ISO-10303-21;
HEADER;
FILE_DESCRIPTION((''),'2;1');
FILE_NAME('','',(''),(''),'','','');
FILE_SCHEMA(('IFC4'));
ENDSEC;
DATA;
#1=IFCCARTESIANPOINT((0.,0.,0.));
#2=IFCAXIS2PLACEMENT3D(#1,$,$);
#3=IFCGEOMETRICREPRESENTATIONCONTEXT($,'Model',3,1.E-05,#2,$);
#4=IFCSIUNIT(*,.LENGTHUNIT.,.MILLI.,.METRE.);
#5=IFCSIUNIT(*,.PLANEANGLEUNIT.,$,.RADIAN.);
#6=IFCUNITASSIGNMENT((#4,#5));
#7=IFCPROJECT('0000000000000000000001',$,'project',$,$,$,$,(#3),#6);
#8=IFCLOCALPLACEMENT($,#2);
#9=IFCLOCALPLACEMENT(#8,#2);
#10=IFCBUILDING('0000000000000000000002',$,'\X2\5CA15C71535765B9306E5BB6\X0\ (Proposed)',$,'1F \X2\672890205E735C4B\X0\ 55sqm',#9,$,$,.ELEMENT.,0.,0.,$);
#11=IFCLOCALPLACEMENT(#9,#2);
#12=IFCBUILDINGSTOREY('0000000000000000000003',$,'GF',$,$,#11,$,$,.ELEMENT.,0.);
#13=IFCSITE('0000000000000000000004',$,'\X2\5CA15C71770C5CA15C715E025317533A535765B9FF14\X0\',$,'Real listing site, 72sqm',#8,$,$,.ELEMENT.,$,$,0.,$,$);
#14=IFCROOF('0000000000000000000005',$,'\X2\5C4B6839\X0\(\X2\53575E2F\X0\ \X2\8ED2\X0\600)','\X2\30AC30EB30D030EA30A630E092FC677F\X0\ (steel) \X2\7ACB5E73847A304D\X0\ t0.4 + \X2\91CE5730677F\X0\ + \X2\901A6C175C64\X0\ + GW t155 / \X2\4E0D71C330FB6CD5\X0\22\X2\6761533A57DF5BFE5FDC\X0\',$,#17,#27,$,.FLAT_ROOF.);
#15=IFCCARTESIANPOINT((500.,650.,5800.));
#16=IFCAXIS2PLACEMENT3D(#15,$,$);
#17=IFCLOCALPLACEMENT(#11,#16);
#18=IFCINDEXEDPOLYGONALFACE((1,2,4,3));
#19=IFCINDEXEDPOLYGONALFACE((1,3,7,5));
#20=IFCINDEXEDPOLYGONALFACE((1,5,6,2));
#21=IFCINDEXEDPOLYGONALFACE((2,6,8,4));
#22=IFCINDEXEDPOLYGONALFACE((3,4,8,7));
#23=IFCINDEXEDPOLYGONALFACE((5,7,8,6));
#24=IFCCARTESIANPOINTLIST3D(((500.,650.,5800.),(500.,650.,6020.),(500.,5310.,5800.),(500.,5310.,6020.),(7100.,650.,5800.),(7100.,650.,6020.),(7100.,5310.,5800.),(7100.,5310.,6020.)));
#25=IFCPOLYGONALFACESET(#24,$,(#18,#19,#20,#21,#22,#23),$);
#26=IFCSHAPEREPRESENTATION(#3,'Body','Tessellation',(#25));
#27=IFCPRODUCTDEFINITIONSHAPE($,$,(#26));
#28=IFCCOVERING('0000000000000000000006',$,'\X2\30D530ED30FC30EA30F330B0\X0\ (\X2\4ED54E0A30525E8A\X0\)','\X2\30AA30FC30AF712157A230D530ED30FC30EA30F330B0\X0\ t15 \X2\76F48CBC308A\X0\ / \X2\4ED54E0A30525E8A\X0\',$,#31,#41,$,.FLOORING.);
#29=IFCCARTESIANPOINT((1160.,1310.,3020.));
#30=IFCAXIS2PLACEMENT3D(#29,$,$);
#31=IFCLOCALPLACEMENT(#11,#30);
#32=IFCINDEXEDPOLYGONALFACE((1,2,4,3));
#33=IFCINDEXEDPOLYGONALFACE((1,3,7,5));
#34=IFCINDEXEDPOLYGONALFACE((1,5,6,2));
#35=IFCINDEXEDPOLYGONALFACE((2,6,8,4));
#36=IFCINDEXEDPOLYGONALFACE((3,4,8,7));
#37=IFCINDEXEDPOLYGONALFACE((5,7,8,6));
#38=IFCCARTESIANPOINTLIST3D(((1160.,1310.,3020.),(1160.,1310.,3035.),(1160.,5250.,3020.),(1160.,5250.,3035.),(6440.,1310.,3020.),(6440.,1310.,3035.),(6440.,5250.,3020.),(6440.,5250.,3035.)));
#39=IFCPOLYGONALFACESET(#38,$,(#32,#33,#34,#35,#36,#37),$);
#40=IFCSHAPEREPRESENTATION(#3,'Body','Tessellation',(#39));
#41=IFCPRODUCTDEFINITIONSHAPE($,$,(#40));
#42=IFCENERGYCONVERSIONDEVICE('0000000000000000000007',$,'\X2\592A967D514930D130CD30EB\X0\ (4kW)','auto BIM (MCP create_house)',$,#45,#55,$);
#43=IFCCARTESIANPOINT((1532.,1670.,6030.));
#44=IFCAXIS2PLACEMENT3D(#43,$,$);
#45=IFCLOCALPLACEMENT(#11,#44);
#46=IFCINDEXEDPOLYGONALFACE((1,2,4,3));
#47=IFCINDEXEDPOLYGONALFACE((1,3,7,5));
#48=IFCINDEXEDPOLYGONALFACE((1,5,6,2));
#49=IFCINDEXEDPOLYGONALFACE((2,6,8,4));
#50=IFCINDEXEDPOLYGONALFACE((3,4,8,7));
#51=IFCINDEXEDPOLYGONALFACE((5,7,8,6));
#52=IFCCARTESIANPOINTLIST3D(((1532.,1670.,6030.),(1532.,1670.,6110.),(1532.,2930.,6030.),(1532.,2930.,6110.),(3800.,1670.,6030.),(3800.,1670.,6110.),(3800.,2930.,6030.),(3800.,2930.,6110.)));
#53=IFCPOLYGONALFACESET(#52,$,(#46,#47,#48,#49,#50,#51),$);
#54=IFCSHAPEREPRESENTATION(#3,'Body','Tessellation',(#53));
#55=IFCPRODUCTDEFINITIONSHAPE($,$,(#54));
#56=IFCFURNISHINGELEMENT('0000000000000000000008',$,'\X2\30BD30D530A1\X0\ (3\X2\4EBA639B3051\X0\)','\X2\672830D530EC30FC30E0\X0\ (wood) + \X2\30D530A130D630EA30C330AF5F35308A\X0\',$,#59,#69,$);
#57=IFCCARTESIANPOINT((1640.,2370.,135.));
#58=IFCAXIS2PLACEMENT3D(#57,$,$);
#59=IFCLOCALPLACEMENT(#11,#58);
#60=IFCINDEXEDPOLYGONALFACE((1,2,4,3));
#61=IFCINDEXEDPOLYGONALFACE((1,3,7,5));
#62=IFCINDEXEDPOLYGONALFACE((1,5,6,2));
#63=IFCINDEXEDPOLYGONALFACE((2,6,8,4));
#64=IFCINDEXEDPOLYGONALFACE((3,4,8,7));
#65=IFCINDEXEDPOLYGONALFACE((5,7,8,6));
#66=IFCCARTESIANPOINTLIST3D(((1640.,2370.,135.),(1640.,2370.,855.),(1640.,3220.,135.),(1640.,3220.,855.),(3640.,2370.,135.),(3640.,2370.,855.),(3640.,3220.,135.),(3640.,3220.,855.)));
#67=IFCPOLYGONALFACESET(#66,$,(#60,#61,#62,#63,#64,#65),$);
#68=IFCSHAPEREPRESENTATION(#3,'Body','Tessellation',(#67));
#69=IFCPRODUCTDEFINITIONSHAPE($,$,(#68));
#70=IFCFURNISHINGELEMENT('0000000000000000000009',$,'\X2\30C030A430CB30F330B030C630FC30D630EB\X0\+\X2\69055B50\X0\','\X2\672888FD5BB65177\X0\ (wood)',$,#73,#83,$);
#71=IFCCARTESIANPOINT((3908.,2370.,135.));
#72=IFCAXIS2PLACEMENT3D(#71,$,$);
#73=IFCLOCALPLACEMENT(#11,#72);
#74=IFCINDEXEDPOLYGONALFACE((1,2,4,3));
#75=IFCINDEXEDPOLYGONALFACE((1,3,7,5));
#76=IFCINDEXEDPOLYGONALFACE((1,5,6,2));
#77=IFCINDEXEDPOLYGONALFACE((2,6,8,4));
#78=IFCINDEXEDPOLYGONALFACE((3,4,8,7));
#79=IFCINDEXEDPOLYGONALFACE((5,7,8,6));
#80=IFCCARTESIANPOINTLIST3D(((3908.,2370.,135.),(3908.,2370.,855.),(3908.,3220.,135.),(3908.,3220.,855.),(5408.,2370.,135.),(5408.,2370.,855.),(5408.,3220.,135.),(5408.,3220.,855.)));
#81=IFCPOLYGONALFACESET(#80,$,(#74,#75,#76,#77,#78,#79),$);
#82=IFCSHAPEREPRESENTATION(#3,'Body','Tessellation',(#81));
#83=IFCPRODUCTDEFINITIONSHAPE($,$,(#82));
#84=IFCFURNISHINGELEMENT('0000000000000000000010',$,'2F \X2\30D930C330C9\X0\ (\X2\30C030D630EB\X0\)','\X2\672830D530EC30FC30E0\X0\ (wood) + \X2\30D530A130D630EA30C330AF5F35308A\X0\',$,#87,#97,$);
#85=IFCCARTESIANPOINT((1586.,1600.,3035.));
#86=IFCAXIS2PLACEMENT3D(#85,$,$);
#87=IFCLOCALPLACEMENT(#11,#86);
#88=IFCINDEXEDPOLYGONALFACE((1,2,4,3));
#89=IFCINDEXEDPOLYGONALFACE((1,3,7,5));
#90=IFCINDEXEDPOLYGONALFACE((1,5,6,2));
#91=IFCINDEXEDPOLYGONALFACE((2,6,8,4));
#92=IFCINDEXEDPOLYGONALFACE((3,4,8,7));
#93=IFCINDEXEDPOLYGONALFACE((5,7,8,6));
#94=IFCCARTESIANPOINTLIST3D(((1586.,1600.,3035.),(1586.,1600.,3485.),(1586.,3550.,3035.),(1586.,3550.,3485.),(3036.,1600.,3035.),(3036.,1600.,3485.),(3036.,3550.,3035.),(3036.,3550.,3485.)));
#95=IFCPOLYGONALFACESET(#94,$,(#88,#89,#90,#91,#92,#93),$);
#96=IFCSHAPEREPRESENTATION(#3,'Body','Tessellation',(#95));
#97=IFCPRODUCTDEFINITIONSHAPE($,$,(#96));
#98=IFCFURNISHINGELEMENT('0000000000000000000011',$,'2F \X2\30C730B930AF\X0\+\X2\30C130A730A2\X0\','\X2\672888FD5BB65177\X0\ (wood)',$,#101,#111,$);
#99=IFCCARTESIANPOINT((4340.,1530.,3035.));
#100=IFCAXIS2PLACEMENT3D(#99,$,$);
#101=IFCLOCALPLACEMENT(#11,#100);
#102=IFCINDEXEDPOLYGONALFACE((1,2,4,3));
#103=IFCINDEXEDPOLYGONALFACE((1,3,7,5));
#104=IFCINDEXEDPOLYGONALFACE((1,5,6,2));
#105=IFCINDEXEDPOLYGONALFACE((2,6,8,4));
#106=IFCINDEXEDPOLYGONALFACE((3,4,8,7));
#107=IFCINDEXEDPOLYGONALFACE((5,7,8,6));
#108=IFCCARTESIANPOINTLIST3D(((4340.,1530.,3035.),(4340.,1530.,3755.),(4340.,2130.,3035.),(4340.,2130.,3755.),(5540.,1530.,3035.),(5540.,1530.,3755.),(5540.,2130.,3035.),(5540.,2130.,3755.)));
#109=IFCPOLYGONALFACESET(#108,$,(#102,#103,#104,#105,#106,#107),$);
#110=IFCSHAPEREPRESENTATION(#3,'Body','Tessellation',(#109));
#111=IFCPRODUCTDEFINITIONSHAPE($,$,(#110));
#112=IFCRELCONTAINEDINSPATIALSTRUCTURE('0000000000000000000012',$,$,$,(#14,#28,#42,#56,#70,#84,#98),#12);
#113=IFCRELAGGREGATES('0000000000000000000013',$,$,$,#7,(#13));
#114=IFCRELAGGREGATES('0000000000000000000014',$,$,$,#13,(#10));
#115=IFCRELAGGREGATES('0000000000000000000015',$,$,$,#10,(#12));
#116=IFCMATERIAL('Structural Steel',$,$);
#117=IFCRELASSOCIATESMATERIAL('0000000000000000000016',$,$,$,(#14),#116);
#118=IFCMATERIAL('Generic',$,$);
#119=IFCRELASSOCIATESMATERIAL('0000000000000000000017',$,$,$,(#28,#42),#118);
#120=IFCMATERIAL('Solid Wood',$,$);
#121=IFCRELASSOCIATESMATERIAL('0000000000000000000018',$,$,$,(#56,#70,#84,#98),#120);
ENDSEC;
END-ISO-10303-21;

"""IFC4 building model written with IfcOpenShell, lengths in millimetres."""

from ifc_helpers import new_model, si_unit, frame, frame_2d, origin, place, context, project, spatial, rectangle, extrude, material, element, save


model = new_model("IFC4")

# Units and contexts
model_context = context("Model", 3, precision=1e-05, world=origin())
ifc_project = project(units=[si_unit("LENGTHUNIT", "METRE", prefix="MILLI"), si_unit("PLANEANGLEUNIT", "RADIAN")], contexts=[model_context])

# Site, building, storey
site_placement = place(None, origin())
site = spatial("IfcSite", under=ifc_project, at=site_placement, Name="岡山県岡山市北区南方４", ObjectType="Real listing site, 72sqm", CompositionType="ELEMENT", RefElevation=0.0)
building_placement = place(site_placement, origin())
building = spatial("IfcBuilding", under=site, at=building_placement, Name="岡山南方の家 (Proposed)", ObjectType="1F 木造平屋 55sqm", CompositionType="ELEMENT", ElevationOfRefHeight=0.0, ElevationOfTerrain=0.0)
storey_placement = place(building_placement, origin())
storey = spatial("IfcBuildingStorey", under=building, at=storey_placement, Name="GF", CompositionType="ELEMENT", Elevation=0.0)

# Shared definitions
ifc_material_1 = material(Name="Solid Wood")

# Shared definitions
ifc_material_2 = material(Name="Generic")

# Roof
ifc_material_3 = material(Name="Structural Steel")
for number, where, name in (
    (1, (500.0, 650.0, 5800.0), "屋根(南帯 軒600)"),
):
    element("IfcRoof", number, at=place(storey_placement, frame(where)), inside=storey, material=ifc_material_3, Name=name, Description="ガルバリウム鋼板 (steel) 立平葺き t0.4 + 野地板 + 通気層 + GW t155 / 不燃・法22条区域対応", PredefinedType="FLAT_ROOF", context=model_context, shape_type="SweptSolid", body=[
        extrude(rectangle(XDim=6600.0, YDim=4660.0, at=frame_2d((3300.0, 2330.0))), frame((500.0, 650.0, 5800.0)), (0.0, 0.0, 1.0), 220.0),
    ])

# Covering
covering_placement = place(storey_placement, frame((1160.0, 1310.0, 3020.0)))
element("IfcCovering", 2, at=covering_placement, inside=storey, material=ifc_material_2, Name="フローリング (仕上げ床)", Description="オーク無垢フローリング t15 直貼り / 仕上げ床", PredefinedType="FLOORING", context=model_context, shape_type="SweptSolid", body=[
    extrude(rectangle(XDim=5280.0, YDim=3940.0, at=frame_2d((2640.0, 1970.0))), frame((1160.0, 1310.0, 3020.0)), (0.0, 0.0, 1.0), 15.0),
])

# Energy conversion device
energy_conversion_device_placement = place(storey_placement, frame((1532.0, 1670.0, 6030.0)))
element("IfcEnergyConversionDevice", 3, at=energy_conversion_device_placement, inside=storey, material=ifc_material_2, Name="太陽光パネル (4kW)", Description="auto BIM (MCP create_house)", context=model_context, shape_type="SweptSolid", body=[
    extrude(rectangle(XDim=2268.0, YDim=1260.0, at=frame_2d((1134.0, 630.0))), frame((1532.0, 1670.0, 6030.0)), (0.0, 0.0, 1.0), 80.0),
])

# Furnishing elements
furnishing_1_placement = place(storey_placement, frame((1640.0, 2370.0, 135.0)))
element("IfcFurnishingElement", 4, at=furnishing_1_placement, inside=storey, material=ifc_material_1, Name="ソファ (3人掛け)", Description="木フレーム (wood) + ファブリック張り", context=model_context, shape_type="SweptSolid", body=[
    extrude(rectangle(XDim=2000.0, YDim=850.0, at=frame_2d((1000.0, 425.0))), frame((1640.0, 2370.0, 135.0)), (0.0, 0.0, 1.0), 720.0),
])
furnishing_2_placement = place(storey_placement, frame((3908.0, 2370.0, 135.0)))
element("IfcFurnishingElement", 5, at=furnishing_2_placement, inside=storey, material=ifc_material_1, Name="ダイニングテーブル+椅子", Description="木製家具 (wood)", context=model_context, shape_type="SweptSolid", body=[
    extrude(rectangle(XDim=1500.0, YDim=850.0, at=frame_2d((750.0, 425.0))), frame((3908.0, 2370.0, 135.0)), (0.0, 0.0, 1.0), 720.0),
])
furnishing_3_placement = place(storey_placement, frame((1586.0, 1600.0, 3035.0)))
element("IfcFurnishingElement", 6, at=furnishing_3_placement, inside=storey, material=ifc_material_1, Name="2F ベッド (ダブル)", Description="木フレーム (wood) + ファブリック張り", context=model_context, shape_type="SweptSolid", body=[
    extrude(rectangle(XDim=1450.0, YDim=1950.0, at=frame_2d((725.0, 975.0))), frame((1586.0, 1600.0, 3035.0)), (0.0, 0.0, 1.0), 450.0),
])
furnishing_4_placement = place(storey_placement, frame((4340.0, 1530.0, 3035.0)))
element("IfcFurnishingElement", 7, at=furnishing_4_placement, inside=storey, material=ifc_material_1, Name="2F デスク+チェア", Description="木製家具 (wood)", context=model_context, shape_type="SweptSolid", body=[
    extrude(rectangle(XDim=1200.0, YDim=600.0, at=frame_2d((600.0, 300.0))), frame((4340.0, 1530.0, 3035.0)), (0.0, 0.0, 1.0), 720.0),
])

save(model, "model.ifc")
